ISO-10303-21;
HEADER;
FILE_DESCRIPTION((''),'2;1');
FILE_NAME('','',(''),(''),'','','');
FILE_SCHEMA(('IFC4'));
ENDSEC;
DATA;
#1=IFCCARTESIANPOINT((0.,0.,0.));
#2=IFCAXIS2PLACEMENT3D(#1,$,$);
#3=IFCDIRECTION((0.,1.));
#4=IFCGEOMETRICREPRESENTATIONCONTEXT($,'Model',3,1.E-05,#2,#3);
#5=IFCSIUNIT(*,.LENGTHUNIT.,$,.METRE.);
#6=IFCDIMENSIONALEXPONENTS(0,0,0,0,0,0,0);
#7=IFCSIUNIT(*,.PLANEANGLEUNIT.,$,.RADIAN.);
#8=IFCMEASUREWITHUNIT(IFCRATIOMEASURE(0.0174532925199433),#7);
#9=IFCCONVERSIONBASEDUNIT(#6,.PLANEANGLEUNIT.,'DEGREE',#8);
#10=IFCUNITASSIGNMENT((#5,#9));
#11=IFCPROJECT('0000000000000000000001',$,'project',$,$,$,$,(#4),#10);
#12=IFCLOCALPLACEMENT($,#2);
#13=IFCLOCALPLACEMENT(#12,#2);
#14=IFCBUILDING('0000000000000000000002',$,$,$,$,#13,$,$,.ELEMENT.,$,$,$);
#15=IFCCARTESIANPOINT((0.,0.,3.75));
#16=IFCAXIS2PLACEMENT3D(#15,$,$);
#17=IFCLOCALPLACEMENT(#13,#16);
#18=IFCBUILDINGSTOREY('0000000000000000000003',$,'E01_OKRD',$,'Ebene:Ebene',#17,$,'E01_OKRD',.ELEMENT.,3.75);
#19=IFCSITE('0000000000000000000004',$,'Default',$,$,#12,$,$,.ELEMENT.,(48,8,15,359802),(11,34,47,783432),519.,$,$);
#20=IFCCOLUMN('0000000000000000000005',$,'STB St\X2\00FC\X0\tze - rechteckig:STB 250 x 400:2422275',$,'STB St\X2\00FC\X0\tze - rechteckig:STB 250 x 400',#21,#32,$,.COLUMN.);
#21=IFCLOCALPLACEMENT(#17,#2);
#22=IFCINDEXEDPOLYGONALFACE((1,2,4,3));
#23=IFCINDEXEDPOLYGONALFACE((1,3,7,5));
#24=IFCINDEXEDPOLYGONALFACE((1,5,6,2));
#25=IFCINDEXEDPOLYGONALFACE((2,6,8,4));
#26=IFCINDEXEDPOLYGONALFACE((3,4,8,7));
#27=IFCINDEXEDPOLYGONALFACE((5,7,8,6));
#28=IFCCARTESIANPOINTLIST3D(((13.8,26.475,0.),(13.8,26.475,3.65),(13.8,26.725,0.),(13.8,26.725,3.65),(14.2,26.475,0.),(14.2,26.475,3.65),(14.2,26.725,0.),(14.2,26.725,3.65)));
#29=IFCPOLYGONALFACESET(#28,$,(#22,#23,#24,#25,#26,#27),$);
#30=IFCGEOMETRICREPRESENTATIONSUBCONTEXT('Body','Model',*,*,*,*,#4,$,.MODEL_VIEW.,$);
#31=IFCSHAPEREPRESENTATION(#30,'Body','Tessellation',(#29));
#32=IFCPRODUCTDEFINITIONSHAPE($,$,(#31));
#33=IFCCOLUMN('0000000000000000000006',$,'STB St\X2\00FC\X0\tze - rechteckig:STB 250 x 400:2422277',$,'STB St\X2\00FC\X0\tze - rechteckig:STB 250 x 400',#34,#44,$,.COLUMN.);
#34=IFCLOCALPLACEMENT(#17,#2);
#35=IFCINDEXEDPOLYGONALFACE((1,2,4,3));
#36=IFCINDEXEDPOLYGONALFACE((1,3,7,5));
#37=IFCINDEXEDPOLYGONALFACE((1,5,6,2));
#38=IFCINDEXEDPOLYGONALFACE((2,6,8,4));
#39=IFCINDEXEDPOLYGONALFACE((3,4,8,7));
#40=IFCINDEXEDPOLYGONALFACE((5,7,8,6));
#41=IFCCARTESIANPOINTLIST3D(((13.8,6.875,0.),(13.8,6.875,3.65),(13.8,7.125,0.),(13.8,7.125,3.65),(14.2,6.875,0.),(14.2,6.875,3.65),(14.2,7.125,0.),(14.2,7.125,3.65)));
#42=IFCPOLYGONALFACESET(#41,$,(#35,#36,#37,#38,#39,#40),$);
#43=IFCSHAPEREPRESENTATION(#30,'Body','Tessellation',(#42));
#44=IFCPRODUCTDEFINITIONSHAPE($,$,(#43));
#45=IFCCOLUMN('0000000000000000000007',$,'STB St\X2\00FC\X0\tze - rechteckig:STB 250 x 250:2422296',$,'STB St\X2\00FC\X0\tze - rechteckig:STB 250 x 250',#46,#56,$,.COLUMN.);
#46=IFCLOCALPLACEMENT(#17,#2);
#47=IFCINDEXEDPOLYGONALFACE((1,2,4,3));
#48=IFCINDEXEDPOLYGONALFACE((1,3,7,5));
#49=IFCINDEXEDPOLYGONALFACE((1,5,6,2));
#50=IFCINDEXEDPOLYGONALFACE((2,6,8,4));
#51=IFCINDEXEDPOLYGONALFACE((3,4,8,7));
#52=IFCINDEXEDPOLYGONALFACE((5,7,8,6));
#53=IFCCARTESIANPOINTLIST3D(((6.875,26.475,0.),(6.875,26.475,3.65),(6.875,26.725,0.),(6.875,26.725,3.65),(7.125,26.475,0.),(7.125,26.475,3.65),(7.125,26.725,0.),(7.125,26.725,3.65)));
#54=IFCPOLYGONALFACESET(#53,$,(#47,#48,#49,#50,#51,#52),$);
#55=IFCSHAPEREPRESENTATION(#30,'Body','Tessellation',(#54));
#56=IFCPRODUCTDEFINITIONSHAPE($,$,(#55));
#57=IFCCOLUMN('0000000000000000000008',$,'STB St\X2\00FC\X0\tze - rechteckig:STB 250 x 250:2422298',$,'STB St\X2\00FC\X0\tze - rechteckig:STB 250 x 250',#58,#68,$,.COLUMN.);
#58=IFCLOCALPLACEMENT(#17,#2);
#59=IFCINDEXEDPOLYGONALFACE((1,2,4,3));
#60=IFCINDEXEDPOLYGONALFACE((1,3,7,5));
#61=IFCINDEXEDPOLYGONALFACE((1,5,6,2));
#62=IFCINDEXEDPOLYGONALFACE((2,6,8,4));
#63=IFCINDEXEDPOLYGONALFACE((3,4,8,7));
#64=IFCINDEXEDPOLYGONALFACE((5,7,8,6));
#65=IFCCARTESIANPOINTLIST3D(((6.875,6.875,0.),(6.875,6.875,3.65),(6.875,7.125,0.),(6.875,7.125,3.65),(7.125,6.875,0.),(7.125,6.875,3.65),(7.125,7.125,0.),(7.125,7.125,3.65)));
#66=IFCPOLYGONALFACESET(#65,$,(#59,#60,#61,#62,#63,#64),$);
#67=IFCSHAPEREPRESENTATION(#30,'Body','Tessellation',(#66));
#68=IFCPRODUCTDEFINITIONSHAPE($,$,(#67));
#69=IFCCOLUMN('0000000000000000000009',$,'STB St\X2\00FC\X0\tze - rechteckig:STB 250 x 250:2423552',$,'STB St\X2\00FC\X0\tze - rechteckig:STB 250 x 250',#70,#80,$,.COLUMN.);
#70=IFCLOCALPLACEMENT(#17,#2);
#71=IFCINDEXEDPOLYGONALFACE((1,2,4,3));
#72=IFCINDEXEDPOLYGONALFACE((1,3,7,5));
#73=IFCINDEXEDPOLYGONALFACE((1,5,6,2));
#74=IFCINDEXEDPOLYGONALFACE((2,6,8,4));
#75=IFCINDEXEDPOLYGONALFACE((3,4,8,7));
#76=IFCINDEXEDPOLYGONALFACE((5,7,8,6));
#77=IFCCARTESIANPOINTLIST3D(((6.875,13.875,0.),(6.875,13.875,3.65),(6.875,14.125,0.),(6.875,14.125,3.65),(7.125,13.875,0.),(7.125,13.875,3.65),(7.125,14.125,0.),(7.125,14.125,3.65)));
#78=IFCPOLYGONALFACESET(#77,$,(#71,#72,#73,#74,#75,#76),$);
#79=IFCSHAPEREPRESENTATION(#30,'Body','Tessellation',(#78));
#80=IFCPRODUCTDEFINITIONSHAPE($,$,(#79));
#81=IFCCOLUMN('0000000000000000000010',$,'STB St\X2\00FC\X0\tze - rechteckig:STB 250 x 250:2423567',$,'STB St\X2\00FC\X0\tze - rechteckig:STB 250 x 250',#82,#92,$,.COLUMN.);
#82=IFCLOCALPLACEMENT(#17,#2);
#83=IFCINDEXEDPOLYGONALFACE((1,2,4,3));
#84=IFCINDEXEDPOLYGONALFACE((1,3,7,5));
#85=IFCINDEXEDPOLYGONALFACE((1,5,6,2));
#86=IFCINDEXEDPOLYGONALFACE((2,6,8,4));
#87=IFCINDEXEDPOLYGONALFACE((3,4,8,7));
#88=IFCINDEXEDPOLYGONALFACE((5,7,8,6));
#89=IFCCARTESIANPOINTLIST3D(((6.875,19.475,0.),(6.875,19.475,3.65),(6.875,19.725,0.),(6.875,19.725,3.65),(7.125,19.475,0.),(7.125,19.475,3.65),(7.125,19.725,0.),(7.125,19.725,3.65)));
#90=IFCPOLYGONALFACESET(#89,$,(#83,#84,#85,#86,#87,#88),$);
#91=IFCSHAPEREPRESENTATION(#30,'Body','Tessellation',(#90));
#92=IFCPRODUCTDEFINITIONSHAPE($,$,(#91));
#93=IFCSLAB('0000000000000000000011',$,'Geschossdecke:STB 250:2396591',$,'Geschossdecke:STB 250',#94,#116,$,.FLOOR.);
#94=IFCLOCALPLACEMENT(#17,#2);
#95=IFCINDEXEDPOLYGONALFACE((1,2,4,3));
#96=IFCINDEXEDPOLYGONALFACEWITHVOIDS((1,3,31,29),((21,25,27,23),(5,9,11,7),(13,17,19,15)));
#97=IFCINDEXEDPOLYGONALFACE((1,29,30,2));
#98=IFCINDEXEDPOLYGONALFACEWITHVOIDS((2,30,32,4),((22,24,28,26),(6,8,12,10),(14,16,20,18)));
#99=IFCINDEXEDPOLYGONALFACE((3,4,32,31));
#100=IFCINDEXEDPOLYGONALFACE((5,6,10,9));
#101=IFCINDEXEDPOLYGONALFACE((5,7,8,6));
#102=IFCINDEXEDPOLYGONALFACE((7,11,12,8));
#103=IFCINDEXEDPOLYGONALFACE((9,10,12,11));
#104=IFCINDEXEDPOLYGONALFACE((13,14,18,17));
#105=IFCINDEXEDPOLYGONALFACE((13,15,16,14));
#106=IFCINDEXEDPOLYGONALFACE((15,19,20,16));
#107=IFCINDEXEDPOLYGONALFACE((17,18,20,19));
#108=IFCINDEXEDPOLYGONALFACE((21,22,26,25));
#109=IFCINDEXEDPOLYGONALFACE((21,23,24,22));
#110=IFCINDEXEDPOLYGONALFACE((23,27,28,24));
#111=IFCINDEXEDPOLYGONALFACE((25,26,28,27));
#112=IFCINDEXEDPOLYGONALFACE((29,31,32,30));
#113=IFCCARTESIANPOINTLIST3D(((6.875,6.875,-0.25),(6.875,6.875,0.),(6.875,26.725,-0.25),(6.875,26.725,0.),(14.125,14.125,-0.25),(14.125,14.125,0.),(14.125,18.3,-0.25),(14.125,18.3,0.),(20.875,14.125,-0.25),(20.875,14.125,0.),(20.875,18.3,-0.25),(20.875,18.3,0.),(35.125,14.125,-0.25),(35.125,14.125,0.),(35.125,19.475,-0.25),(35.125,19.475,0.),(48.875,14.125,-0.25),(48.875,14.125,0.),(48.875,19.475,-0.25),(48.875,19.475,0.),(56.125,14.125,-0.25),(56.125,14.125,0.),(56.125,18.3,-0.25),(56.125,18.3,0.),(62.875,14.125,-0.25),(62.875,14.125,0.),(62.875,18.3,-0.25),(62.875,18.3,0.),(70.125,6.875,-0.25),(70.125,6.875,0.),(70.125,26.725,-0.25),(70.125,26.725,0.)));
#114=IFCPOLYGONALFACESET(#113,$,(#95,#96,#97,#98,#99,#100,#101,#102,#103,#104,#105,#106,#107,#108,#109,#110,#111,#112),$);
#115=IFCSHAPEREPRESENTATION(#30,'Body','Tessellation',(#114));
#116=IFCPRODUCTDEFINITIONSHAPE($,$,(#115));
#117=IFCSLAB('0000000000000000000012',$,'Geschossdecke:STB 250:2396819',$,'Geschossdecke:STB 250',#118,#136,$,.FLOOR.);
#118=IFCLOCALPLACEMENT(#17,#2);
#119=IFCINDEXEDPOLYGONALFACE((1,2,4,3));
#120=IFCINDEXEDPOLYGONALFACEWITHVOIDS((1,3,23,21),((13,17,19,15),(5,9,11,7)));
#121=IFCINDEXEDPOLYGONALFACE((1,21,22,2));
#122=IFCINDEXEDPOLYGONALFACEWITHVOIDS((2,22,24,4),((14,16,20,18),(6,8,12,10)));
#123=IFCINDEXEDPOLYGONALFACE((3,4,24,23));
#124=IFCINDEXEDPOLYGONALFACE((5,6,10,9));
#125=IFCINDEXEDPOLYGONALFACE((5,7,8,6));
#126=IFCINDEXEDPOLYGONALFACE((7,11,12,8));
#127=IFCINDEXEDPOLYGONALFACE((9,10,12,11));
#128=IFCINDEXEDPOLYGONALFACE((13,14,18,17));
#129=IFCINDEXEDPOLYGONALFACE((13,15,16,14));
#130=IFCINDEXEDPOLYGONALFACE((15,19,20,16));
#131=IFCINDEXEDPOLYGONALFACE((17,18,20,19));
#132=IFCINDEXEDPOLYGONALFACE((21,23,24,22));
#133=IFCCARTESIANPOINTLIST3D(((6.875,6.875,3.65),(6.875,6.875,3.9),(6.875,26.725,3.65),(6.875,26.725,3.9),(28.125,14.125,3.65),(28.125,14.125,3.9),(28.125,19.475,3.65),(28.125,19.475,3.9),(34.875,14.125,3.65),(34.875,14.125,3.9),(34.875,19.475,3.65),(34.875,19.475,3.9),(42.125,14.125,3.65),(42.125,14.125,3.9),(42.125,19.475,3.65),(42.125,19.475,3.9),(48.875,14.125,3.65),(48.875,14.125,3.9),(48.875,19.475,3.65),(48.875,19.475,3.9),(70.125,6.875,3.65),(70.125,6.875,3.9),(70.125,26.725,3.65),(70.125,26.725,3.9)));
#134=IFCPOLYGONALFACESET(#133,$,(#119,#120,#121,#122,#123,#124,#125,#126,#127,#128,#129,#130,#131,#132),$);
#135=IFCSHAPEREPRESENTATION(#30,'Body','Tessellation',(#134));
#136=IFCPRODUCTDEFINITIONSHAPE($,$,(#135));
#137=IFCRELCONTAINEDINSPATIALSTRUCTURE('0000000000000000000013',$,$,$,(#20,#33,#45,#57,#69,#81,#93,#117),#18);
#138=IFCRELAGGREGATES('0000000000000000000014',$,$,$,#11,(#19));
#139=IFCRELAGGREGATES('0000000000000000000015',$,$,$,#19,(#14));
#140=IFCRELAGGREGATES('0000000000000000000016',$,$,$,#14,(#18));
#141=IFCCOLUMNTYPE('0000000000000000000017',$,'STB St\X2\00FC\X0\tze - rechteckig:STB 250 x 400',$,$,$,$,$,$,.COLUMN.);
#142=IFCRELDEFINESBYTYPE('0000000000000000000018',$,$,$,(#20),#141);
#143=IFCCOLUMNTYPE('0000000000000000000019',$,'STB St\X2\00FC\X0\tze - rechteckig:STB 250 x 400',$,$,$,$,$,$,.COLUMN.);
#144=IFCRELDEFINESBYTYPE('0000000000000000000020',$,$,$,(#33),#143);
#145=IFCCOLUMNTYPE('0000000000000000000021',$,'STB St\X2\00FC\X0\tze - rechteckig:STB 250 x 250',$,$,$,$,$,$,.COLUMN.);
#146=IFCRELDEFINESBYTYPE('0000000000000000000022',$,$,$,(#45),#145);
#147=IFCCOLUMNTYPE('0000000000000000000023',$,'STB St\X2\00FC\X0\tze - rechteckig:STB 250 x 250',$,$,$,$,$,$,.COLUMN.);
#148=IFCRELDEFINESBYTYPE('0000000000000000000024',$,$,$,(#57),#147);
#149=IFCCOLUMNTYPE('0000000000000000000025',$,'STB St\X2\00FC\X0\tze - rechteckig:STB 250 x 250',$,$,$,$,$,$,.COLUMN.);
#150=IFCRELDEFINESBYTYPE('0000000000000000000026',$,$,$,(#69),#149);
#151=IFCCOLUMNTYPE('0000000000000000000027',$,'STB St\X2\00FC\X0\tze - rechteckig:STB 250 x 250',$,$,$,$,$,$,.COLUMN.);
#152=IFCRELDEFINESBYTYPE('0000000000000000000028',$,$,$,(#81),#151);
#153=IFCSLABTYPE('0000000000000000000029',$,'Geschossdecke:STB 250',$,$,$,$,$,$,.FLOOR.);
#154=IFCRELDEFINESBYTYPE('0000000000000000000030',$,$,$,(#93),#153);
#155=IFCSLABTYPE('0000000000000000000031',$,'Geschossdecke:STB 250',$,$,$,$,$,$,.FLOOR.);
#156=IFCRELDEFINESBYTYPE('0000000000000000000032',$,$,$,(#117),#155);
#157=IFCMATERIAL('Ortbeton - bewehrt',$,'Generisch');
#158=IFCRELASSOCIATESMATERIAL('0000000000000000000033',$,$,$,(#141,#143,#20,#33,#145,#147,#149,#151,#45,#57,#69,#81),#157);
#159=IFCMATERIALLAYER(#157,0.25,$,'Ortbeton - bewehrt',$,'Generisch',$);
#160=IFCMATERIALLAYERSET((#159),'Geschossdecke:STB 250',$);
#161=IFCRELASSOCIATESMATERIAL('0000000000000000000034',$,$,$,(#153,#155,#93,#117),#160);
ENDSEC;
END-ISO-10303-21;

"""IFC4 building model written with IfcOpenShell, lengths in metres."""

from ifc_helpers import new_model, entity, si_unit, converted_unit, direction, frame, frame_2d, origin, origin_2d_with_axis, place, context, subcontext, project, spatial, rectangle, extrude, source, transform, mapped, material, layer, layer_set, layer_usage, material_profile, profile_set, profile_usage, type_object, type_shapes, element, save


model = new_model("IFC4")

# Units and contexts
model_context = context("Model", 3, precision=1e-05, world=origin(), true_north=direction((0.0, 1.0)))
body_context = subcontext(model_context, "Body", "Model", "MODEL_VIEW")
ifc_project = project(units=[si_unit("LENGTHUNIT", "METRE"), converted_unit("PLANEANGLEUNIT", "DEGREE", entity("IfcRatioMeasure", 0.0174532925199433), si_unit("PLANEANGLEUNIT", "RADIAN"), dimensions=[0, 0, 0, 0, 0, 0, 0])], contexts=[model_context])

# Site, building, storey
site_placement = place(None, frame((0.0, 0.0, 0.0)))
site = spatial("IfcSite", under=ifc_project, at=site_placement, Name="Default", CompositionType="ELEMENT", RefLatitude=(48, 8, 15, 359802), RefLongitude=(11, 34, 47, 783432), RefElevation=519.0)
building_placement = place(site_placement, origin())
building = spatial("IfcBuilding", under=site, at=building_placement, CompositionType="ELEMENT")
storey_placement = place(building_placement, frame((0.0, 0.0, 3.75)))
storey = spatial("IfcBuildingStorey", under=building, at=storey_placement, Name="E01_OKRD", ObjectType="Ebene:Ebene", LongName="E01_OKRD", CompositionType="ELEMENT", Elevation=3.75)

# Columns
ifc_material_1 = material(Name="Ortbeton - bewehrt", Category="Generisch")
ifc_material_profile_1 = material_profile(ifc_material_1, rectangle(XDim=0.4, YDim=0.25, at=frame_2d((0.0, 0.0), x_axis=(1.0, 0.0))), Name="STB 250 x 400")
ifc_profile_set_1 = profile_set([ifc_material_profile_1], Name="STB 250 x 400")
ifc_profile_usage_1 = profile_usage(ifc_profile_set_1)
column_type_1 = type_object("IfcColumnType", Name="STB Stütze - rechteckig:STB 250 x 400", PredefinedType="COLUMN", material=ifc_profile_set_1)
shared_shape_1 = source(origin(), body_context, "Body", "SweptSolid", [
    extrude(rectangle(XDim=0.4, YDim=0.25, at=frame_2d((0.0, 0.0), x_axis=(1.0, 0.0))), frame((0.2, 0.125, 0.0), z_axis=(0.0, 0.0, 1.0), x_axis=(-1.0, 0.0, 0.0)), (0.0, 0.0, 1.0), 3.65),
])
type_shapes(column_type_1, [shared_shape_1])
column_1_placement = place(storey_placement, frame((13.8, 26.475, 0.0)))
element("IfcColumn", 1, at=column_1_placement, inside=storey, type_object=column_type_1, material=ifc_profile_usage_1, Name="STB Stütze - rechteckig:STB 250 x 400:2422275", ObjectType="STB Stütze - rechteckig:STB 250 x 400", PredefinedType="COLUMN", context=body_context, shape_type="MappedRepresentation", body=[
    mapped(shared_shape_1, transform((0.0, 0.0, 0.0), scale=1.0)),
])
ifc_profile_usage_2 = profile_usage(ifc_profile_set_1)
column_type_2 = type_object("IfcColumnType", Name="STB Stütze - rechteckig:STB 250 x 400", PredefinedType="COLUMN", material=ifc_profile_set_1)
shared_shape_2 = source(origin(), body_context, "Body", "SweptSolid", [
    extrude(rectangle(XDim=0.4, YDim=0.25, at=frame_2d((0.0, 0.0), x_axis=(1.0, 0.0))), frame((0.2, 0.125, 0.0), z_axis=(0.0, 0.0, 1.0), x_axis=(-1.0, 0.0, 0.0)), (0.0, 0.0, 1.0), 3.65),
])
type_shapes(column_type_2, [shared_shape_2])
column_2_placement = place(storey_placement, frame((13.8, 6.875, 0.0)))
element("IfcColumn", 2, at=column_2_placement, inside=storey, type_object=column_type_2, material=ifc_profile_usage_2, Name="STB Stütze - rechteckig:STB 250 x 400:2422277", ObjectType="STB Stütze - rechteckig:STB 250 x 400", PredefinedType="COLUMN", context=body_context, shape_type="MappedRepresentation", body=[
    mapped(shared_shape_2, transform((0.0, 0.0, 0.0), scale=1.0)),
])
ifc_material_profile_2 = material_profile(ifc_material_1, rectangle(XDim=0.25, YDim=0.25, at=origin_2d_with_axis()), Name="STB 250 x 250")
ifc_profile_set_2 = profile_set([ifc_material_profile_2], Name="STB 250 x 250")
ifc_profile_usage_3 = profile_usage(ifc_profile_set_2)
column_type_3 = type_object("IfcColumnType", Name="STB Stütze - rechteckig:STB 250 x 250", PredefinedType="COLUMN", material=ifc_profile_set_2)
shared_shape_3 = source(origin(), body_context, "Body", "SweptSolid", [
    extrude(rectangle(XDim=0.25, YDim=0.25, at=frame_2d((0.0, 0.0), x_axis=(1.0, 0.0))), frame((0.125, 0.125, 0.0), z_axis=(0.0, 0.0, 1.0), x_axis=(-1.0, 0.0, 0.0)), (0.0, 0.0, 1.0), 3.65),
])
type_shapes(column_type_3, [shared_shape_3])
column_3_placement = place(storey_placement, frame((6.875, 26.475, 0.0)))
element("IfcColumn", 3, at=column_3_placement, inside=storey, type_object=column_type_3, material=ifc_profile_usage_3, Name="STB Stütze - rechteckig:STB 250 x 250:2422296", ObjectType="STB Stütze - rechteckig:STB 250 x 250", PredefinedType="COLUMN", context=body_context, shape_type="MappedRepresentation", body=[
    mapped(shared_shape_3, transform((0.0, 0.0, 0.0), scale=1.0)),
])
ifc_profile_usage_4 = profile_usage(ifc_profile_set_2)
column_type_4 = type_object("IfcColumnType", Name="STB Stütze - rechteckig:STB 250 x 250", PredefinedType="COLUMN", material=ifc_profile_set_2)
shared_shape_4 = source(origin(), body_context, "Body", "SweptSolid", [
    extrude(rectangle(XDim=0.25, YDim=0.25, at=origin_2d_with_axis()), frame((0.125, 0.125, 0.0), z_axis=(0.0, 0.0, 1.0), x_axis=(-1.0, 0.0, 0.0)), (0.0, 0.0, 1.0), 3.65),
])
type_shapes(column_type_4, [shared_shape_4])
column_4_placement = place(storey_placement, frame((6.875, 6.875, 0.0)))
element("IfcColumn", 4, at=column_4_placement, inside=storey, type_object=column_type_4, material=ifc_profile_usage_4, Name="STB Stütze - rechteckig:STB 250 x 250:2422298", ObjectType="STB Stütze - rechteckig:STB 250 x 250", PredefinedType="COLUMN", context=body_context, shape_type="MappedRepresentation", body=[
    mapped(shared_shape_4, transform((0.0, 0.0, 0.0), scale=1.0)),
])
ifc_profile_usage_5 = profile_usage(ifc_profile_set_2)
column_type_5 = type_object("IfcColumnType", Name="STB Stütze - rechteckig:STB 250 x 250", PredefinedType="COLUMN", material=ifc_profile_set_2)
shared_shape_5 = source(origin(), body_context, "Body", "SweptSolid", [
    extrude(rectangle(XDim=0.25, YDim=0.25, at=frame_2d((0.0, 0.0), x_axis=(1.0, 0.0))), frame((0.125, 0.125, 0.0), z_axis=(0.0, 0.0, 1.0), x_axis=(0.0, 1.0, 0.0)), (0.0, 0.0, 1.0), 3.65),
])
type_shapes(column_type_5, [shared_shape_5])
column_5_placement = place(storey_placement, frame((6.875, 13.875, 0.0)))
element("IfcColumn", 5, at=column_5_placement, inside=storey, type_object=column_type_5, material=ifc_profile_usage_5, Name="STB Stütze - rechteckig:STB 250 x 250:2423552", ObjectType="STB Stütze - rechteckig:STB 250 x 250", PredefinedType="COLUMN", context=body_context, shape_type="MappedRepresentation", body=[
    mapped(shared_shape_5, transform((0.0, 0.0, 0.0), scale=1.0)),
])
ifc_profile_usage_6 = profile_usage(ifc_profile_set_2)
column_type_6 = type_object("IfcColumnType", Name="STB Stütze - rechteckig:STB 250 x 250", PredefinedType="COLUMN", material=ifc_profile_set_2)
shared_shape_6 = source(origin(), body_context, "Body", "SweptSolid", [
    extrude(rectangle(XDim=0.25, YDim=0.25, at=frame_2d((0.0, 0.0), x_axis=(1.0, 0.0))), frame((0.125, 0.125, 0.0), z_axis=(0.0, 0.0, 1.0), x_axis=(0.0, 1.0, 0.0)), (0.0, 0.0, 1.0), 3.65),
])
type_shapes(column_type_6, [shared_shape_6])
column_6_placement = place(storey_placement, frame((6.875, 19.475, 0.0)))
element("IfcColumn", 6, at=column_6_placement, inside=storey, type_object=column_type_6, material=ifc_profile_usage_6, Name="STB Stütze - rechteckig:STB 250 x 250:2423567", ObjectType="STB Stütze - rechteckig:STB 250 x 250", PredefinedType="COLUMN", context=body_context, shape_type="MappedRepresentation", body=[
    mapped(shared_shape_6, transform((0.0, 0.0, 0.0), scale=1.0)),
])

# Slabs, openings
ifc_layer_1 = layer(ifc_material_1, 0.25, Name="Ortbeton - bewehrt", Category="Generisch")
ifc_layer_set_1 = layer_set([ifc_layer_1], Name="Geschossdecke:STB 250")
ifc_layer_usage_1 = layer_usage(ifc_layer_set_1, "AXIS3", "POSITIVE", 0.0)
slab_type_1 = type_object("IfcSlabType", Name="Geschossdecke:STB 250", PredefinedType="FLOOR", material=ifc_layer_set_1)
slab_1_placement = place(storey_placement, frame((6.875, 6.875, -0.25)))
slab_1 = element("IfcSlab", 7, at=slab_1_placement, inside=storey, type_object=slab_type_1, material=ifc_layer_usage_1, Name="Geschossdecke:STB 250:2396591", ObjectType="Geschossdecke:STB 250", PredefinedType="FLOOR", context=body_context, shape_type="SweptSolid", body=[
    extrude(rectangle(XDim=19.85, YDim=63.25, at=frame_2d((0.0, 0.0), x_axis=(0.0, -1.0))), frame((31.625, 9.925, 0.25), z_axis=(0.0, 0.0, -1.0), x_axis=(-1.0, 0.0, 0.0)), (0.0, 0.0, 1.0), 0.25),
])
opening_1_placement = place(slab_1_placement, frame((35.125, 9.925, 0.25)))
element("IfcOpeningElement", 8, at=opening_1_placement, cuts=slab_1, ObjectType="Opening", context=body_context, shape_type="SweptSolid", body=[
    extrude(rectangle(XDim=13.75, YDim=5.35, at=origin_2d_with_axis()), frame((0.0, 0.0, 0.0), z_axis=(0.0, 0.0, -1.0), x_axis=(-1.0, 0.0, 0.0)), (0.0, 0.0, 1.0), 0.25),
])
opening_2_placement = place(slab_1_placement, frame((10.625, 9.3375, 0.25)))
element("IfcOpeningElement", 9, at=opening_2_placement, cuts=slab_1, ObjectType="Opening", context=body_context, shape_type="SweptSolid", body=[
    extrude(rectangle(XDim=4.175, YDim=6.75, at=origin_2d_with_axis()), frame((0.0, 0.0, 0.0), z_axis=(0.0, 0.0, -1.0), x_axis=(0.0, 1.0, 0.0)), (0.0, 0.0, 1.0), 0.25),
])
opening_3_placement = place(slab_1_placement, frame((52.625, 9.3375, 0.25)))
element("IfcOpeningElement", 10, at=opening_3_placement, cuts=slab_1, ObjectType="Opening", context=body_context, shape_type="SweptSolid", body=[
    extrude(rectangle(XDim=6.75, YDim=4.175, at=origin_2d_with_axis()), frame((0.0, 0.0, 0.0), z_axis=(0.0, 0.0, -1.0), x_axis=(-1.0, 0.0, 0.0)), (0.0, 0.0, 1.0), 0.25),
])
ifc_layer_usage_2 = layer_usage(ifc_layer_set_1, "AXIS3", "POSITIVE", 0.0)
slab_type_2 = type_object("IfcSlabType", Name="Geschossdecke:STB 250", PredefinedType="FLOOR", material=ifc_layer_set_1)
slab_2_placement = place(storey_placement, frame((6.875, 6.875, 3.65)))
slab_2 = element("IfcSlab", 11, at=slab_2_placement, inside=storey, type_object=slab_type_2, material=ifc_layer_usage_2, Name="Geschossdecke:STB 250:2396819", ObjectType="Geschossdecke:STB 250", PredefinedType="FLOOR", context=body_context, shape_type="SweptSolid", body=[
    extrude(rectangle(XDim=19.85, YDim=63.25, at=frame_2d((0.0, 0.0), x_axis=(0.0, -1.0))), frame((31.625, 9.925, 0.25), z_axis=(0.0, 0.0, -1.0), x_axis=(-1.0, 0.0, 0.0)), (0.0, 0.0, 1.0), 0.25),
])
opening_4_placement = place(slab_2_placement, frame((38.625, 9.925, 0.25)))
element("IfcOpeningElement", 12, at=opening_4_placement, cuts=slab_2, ObjectType="Opening", context=body_context, shape_type="SweptSolid", body=[
    extrude(rectangle(XDim=6.75, YDim=5.35, at=origin_2d_with_axis()), frame((0.0, 0.0, 0.0), z_axis=(0.0, 0.0, -1.0), x_axis=(-1.0, 0.0, 0.0)), (0.0, 0.0, 1.0), 0.25),
])
opening_5_placement = place(slab_2_placement, frame((24.625, 9.925, 0.25)))
element("IfcOpeningElement", 13, at=opening_5_placement, cuts=slab_2, ObjectType="Opening", context=body_context, shape_type="SweptSolid", body=[
    extrude(rectangle(XDim=6.75, YDim=5.35, at=origin_2d_with_axis()), frame((0.0, 0.0, 0.0), z_axis=(0.0, 0.0, -1.0), x_axis=(-1.0, 0.0, 0.0)), (0.0, 0.0, 1.0), 0.25),
])

save(model, "model.ifc")
